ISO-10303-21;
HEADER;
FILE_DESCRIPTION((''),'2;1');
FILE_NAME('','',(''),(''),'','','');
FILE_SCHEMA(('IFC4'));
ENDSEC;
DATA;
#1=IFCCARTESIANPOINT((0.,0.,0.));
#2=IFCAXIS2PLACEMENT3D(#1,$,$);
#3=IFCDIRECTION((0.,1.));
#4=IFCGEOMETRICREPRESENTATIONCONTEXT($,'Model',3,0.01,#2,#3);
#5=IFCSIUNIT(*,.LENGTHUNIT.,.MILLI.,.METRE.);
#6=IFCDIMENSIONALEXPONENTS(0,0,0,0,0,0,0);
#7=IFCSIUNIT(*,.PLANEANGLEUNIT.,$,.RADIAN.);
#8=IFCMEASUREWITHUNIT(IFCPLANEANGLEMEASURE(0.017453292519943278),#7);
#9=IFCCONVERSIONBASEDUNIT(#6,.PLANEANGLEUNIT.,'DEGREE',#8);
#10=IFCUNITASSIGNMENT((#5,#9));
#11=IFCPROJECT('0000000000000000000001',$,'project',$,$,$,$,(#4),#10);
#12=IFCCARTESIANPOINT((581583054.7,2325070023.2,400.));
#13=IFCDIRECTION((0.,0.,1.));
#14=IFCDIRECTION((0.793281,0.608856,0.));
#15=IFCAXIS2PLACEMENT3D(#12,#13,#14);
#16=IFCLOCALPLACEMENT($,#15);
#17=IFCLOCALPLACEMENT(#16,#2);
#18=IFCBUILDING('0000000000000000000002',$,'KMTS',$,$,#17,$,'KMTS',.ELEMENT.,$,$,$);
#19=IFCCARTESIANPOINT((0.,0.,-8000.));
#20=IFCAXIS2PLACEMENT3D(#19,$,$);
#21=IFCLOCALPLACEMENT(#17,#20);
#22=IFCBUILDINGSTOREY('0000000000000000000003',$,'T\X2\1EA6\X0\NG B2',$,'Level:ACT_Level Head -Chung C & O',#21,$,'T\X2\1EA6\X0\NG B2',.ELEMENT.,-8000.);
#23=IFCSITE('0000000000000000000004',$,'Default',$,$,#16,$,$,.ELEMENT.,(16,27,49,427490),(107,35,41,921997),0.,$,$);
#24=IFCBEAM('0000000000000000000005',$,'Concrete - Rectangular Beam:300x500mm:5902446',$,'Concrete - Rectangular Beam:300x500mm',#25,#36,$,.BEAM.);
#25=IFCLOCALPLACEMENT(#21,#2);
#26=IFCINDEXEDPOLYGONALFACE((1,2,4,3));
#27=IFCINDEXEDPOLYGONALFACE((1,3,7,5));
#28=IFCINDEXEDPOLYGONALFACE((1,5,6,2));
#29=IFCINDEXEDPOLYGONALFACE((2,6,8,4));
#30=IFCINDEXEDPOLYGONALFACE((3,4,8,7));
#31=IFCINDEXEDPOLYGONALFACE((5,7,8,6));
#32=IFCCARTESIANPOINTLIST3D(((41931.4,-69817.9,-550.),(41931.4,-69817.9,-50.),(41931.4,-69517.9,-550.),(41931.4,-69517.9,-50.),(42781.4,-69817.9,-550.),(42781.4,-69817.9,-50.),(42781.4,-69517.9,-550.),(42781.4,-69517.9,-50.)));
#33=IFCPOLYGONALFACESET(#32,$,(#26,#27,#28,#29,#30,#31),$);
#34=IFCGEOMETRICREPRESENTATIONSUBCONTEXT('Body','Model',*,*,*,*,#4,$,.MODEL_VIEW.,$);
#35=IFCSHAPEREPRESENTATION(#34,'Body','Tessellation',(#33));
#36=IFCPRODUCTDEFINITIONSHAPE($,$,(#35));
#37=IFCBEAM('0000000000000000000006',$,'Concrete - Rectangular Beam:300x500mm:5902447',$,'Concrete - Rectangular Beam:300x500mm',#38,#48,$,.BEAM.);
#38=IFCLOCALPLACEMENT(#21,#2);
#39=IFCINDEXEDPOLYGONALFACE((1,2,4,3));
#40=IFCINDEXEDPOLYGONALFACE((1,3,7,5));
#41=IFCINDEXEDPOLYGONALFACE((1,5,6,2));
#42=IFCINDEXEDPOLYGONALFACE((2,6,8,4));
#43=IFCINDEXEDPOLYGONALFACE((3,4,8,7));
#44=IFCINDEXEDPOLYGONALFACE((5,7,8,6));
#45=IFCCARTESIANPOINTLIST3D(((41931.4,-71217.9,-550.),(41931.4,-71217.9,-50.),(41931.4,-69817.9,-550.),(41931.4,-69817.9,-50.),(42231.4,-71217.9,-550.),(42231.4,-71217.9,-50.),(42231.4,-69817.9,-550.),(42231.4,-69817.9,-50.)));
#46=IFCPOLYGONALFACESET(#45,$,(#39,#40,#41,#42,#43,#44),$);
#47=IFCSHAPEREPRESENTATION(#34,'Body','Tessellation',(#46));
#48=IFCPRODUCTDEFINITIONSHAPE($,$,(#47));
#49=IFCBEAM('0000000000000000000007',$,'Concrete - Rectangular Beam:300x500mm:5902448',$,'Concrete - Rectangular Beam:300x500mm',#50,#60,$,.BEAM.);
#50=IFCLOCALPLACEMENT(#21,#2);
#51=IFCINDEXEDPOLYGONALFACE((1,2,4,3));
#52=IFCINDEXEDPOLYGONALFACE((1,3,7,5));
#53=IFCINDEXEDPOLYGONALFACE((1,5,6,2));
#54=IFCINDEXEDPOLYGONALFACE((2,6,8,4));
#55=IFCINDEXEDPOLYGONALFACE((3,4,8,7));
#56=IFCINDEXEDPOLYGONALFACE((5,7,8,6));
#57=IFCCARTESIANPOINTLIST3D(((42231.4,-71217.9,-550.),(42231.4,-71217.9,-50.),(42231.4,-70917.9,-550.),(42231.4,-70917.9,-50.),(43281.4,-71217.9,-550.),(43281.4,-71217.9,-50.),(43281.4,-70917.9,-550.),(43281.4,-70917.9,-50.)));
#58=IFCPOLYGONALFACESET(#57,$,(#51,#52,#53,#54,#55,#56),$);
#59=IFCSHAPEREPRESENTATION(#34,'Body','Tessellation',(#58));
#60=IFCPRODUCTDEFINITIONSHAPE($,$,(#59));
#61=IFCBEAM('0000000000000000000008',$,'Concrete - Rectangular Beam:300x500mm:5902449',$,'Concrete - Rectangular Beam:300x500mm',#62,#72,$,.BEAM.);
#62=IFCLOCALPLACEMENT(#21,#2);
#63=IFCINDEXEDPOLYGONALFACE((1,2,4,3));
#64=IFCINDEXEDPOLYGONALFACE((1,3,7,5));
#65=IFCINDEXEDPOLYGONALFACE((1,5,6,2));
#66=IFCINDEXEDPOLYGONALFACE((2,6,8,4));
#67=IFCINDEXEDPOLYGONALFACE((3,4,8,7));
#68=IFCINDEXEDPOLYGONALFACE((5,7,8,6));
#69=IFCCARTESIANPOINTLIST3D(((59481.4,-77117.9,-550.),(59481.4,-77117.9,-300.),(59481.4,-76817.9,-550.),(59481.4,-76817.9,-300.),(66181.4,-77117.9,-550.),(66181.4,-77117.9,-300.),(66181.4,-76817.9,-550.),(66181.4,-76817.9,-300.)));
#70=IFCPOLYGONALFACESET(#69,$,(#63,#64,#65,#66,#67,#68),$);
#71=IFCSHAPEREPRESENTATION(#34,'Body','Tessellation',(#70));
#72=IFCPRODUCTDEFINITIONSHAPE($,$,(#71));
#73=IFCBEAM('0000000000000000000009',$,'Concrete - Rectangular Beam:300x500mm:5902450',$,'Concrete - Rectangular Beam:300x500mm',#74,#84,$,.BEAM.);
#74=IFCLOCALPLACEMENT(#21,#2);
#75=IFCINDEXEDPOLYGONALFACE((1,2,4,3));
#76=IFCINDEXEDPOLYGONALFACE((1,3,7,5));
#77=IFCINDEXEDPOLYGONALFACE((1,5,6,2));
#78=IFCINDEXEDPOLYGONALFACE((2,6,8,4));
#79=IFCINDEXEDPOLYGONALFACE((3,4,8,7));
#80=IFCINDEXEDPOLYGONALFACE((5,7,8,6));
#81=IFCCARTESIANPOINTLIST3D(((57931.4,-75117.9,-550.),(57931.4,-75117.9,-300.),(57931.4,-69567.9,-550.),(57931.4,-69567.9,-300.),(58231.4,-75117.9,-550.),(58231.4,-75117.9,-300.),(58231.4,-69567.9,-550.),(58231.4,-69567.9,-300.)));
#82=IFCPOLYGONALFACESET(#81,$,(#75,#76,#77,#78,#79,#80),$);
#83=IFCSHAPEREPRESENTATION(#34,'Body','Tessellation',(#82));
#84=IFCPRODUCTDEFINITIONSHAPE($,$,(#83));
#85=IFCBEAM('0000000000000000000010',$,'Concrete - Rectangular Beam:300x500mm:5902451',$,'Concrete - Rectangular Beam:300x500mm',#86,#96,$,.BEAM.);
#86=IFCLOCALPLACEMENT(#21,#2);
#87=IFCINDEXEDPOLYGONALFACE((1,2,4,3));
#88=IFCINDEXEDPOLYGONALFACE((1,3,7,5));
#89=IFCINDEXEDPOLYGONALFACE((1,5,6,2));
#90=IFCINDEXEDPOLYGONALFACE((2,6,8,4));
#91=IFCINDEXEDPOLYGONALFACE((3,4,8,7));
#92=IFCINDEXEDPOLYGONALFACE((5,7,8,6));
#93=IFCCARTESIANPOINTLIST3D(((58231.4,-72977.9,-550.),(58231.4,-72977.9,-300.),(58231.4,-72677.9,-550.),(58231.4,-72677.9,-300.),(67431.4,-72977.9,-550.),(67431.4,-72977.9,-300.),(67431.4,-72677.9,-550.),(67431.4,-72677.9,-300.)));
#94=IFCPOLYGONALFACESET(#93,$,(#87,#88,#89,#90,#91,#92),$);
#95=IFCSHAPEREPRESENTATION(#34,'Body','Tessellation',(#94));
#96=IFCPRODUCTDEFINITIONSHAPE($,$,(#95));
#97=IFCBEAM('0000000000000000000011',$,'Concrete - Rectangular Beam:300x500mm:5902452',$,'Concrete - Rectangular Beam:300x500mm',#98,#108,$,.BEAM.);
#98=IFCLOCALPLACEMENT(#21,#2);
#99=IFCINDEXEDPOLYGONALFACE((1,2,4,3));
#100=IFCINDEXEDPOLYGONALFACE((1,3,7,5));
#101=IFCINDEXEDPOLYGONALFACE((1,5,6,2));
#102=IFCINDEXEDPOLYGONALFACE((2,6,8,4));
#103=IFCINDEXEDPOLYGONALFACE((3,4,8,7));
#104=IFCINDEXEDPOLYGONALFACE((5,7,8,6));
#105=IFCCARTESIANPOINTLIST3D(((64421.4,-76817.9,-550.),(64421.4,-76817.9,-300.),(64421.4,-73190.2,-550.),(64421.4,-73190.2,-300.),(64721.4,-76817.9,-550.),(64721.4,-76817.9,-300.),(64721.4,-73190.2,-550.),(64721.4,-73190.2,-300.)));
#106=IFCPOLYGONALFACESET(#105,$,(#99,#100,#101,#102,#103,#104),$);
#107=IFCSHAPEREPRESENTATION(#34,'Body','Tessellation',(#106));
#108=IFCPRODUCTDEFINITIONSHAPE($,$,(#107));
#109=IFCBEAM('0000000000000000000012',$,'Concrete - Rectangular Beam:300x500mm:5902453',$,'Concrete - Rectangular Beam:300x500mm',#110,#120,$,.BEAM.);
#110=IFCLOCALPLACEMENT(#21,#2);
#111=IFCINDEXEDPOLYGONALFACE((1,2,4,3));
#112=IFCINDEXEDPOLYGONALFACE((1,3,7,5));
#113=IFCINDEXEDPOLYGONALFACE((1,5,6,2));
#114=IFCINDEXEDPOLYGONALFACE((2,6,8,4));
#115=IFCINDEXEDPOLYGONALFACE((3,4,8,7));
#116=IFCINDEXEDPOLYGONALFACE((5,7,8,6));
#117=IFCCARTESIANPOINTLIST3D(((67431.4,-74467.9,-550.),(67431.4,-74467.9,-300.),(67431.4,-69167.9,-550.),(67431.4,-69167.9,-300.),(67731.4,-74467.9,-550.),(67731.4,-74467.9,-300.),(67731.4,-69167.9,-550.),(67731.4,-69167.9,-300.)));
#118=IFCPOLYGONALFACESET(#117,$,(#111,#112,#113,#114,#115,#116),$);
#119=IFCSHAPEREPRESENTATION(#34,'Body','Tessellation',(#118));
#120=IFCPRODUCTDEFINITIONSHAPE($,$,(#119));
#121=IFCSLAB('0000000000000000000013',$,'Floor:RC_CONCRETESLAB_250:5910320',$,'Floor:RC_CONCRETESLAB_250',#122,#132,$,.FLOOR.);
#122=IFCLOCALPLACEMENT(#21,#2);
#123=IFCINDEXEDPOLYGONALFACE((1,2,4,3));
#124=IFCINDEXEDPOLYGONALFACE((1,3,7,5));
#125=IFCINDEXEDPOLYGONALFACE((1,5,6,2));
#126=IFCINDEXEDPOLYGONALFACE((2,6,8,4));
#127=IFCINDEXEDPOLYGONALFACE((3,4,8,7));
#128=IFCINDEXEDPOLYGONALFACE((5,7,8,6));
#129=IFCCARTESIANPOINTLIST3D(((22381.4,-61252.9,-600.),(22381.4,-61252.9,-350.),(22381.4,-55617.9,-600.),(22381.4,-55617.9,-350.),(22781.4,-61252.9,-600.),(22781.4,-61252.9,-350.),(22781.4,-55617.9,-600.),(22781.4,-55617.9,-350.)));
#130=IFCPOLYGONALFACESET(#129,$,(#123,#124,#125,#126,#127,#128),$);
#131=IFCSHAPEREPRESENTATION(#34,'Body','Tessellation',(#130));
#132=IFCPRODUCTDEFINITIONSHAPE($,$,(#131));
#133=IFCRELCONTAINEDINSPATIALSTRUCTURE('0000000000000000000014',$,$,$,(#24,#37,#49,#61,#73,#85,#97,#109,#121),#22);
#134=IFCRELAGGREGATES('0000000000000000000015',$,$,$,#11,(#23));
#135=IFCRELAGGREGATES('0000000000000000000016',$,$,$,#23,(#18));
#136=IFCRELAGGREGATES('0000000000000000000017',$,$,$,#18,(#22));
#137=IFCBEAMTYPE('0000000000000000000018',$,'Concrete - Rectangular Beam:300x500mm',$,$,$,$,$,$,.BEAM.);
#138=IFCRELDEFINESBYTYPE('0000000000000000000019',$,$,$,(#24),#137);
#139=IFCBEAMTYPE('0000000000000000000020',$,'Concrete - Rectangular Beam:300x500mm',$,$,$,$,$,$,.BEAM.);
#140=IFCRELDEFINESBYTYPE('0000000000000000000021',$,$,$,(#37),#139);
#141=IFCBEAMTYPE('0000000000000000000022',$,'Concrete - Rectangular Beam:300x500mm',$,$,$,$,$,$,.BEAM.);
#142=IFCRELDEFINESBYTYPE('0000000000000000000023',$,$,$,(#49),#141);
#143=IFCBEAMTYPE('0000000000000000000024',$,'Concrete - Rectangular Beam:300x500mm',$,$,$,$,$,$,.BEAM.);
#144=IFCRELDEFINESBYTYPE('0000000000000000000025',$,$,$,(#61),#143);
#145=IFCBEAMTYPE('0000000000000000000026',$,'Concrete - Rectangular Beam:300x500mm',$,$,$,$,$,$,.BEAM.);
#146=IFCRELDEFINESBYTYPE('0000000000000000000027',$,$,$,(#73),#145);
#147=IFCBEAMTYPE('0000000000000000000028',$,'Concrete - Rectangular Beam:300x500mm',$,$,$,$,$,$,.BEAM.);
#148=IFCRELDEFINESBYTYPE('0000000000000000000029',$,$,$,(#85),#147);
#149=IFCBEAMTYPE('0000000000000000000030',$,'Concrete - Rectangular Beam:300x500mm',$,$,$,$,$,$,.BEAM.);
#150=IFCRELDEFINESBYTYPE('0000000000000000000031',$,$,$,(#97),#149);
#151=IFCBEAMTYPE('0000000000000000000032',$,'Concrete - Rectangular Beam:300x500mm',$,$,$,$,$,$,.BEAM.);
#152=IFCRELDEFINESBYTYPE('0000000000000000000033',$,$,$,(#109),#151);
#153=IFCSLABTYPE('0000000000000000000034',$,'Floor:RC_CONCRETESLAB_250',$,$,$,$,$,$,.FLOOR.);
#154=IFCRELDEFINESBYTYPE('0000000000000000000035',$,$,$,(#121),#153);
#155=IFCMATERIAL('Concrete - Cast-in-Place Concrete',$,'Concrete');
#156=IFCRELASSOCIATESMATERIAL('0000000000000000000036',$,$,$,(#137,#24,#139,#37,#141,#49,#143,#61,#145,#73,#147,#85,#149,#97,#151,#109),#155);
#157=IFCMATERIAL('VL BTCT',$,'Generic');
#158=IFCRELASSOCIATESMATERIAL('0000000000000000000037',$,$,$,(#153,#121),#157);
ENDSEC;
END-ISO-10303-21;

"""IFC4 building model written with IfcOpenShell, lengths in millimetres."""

from ifc_helpers import new_model, entity, si_unit, converted_unit, direction, frame, origin, place, context, subcontext, project, spatial, indexed_curve, outline, extrude, source, transform, mapped, material, type_object, type_shapes, element, save


model = new_model("IFC4")

# Units and contexts
model_context = context("Model", 3, precision=0.01, world=origin(), true_north=direction((0.0, 1.0)))
body_context = subcontext(model_context, "Body", "Model", "MODEL_VIEW")
ifc_project = project(units=[si_unit("LENGTHUNIT", "METRE", prefix="MILLI"), converted_unit("PLANEANGLEUNIT", "DEGREE", entity("IfcPlaneAngleMeasure", 0.017453292519943278), si_unit("PLANEANGLEUNIT", "RADIAN"), dimensions=[0, 0, 0, 0, 0, 0, 0])], contexts=[model_context])

# Site, building, storey
site_placement = place(None, frame((581583054.7, 2325070023.2, 400.0), z_axis=(0.0, 0.0, 1.0), x_axis=(0.793281, 0.608856, 0.0)))
site = spatial("IfcSite", under=ifc_project, at=site_placement, Name="Default", CompositionType="ELEMENT", RefLatitude=(16, 27, 49, 427490), RefLongitude=(107, 35, 41, 921997), RefElevation=0.0)
building_placement = place(site_placement, origin())
building = spatial("IfcBuilding", under=site, at=building_placement, Name="KMTS", LongName="KMTS", CompositionType="ELEMENT")
storey_placement = place(building_placement, frame((0.0, 0.0, -8000.0)))
storey = spatial("IfcBuildingStorey", under=building, at=storey_placement, Name="TẦNG B2", ObjectType="Level:ACT_Level Head -Chung C & O", LongName="TẦNG B2", CompositionType="ELEMENT", Elevation=-8000.0)

# Shared definitions
ifc_material_1 = material(Name="VL BTCT", Category="Generic")

# Beams
ifc_material_2 = material(Name="Concrete - Cast-in-Place Concrete", Category="Concrete")
beam_type_1 = type_object("IfcBeamType", Name="Concrete - Rectangular Beam:300x500mm", PredefinedType="BEAM", material=ifc_material_2)
shared_shape_1 = source(origin(), body_context, "Body", "SweptSolid", [
    extrude(outline(indexed_curve([(-250.0, -150.0), (250.0, -150.0), (250.0, 150.0), (-250.0, 150.0), (-250.0, -150.0)], self_intersect=False)), frame((42781.4, -69667.9, -8300.0), z_axis=(-1.0, 0.0, 0.0), x_axis=(0.0, 0.0, -1.0)), (0.0, 0.0, 1.0), 850.0),
])
type_shapes(beam_type_1, [shared_shape_1])
beam_1_placement = place(storey_placement, frame((0.0, 0.0, 8000.0)))
element("IfcBeam", 1, at=beam_1_placement, inside=storey, type_object=beam_type_1, material=ifc_material_2, Name="Concrete - Rectangular Beam:300x500mm:5902446", ObjectType="Concrete - Rectangular Beam:300x500mm", PredefinedType="BEAM", context=body_context, shape_type="MappedRepresentation", body=[
    mapped(shared_shape_1, transform((0.0, 0.0, 0.0), scale=1.0)),
])
beam_type_2 = type_object("IfcBeamType", Name="Concrete - Rectangular Beam:300x500mm", PredefinedType="BEAM", material=ifc_material_2)
shared_shape_2 = source(origin(), body_context, "Body", "SweptSolid", [
    extrude(outline(indexed_curve([(-150.0, -250.0), (150.0, -250.0), (150.0, 250.0), (-150.0, 250.0), (-150.0, -250.0)], self_intersect=False)), frame((42081.4, -69817.9, -8300.0), z_axis=(0.0, -1.0, 0.0), x_axis=(-1.0, 0.0, 0.0)), (0.0, 0.0, 1.0), 1400.0),
])
type_shapes(beam_type_2, [shared_shape_2])
beam_2_placement = place(storey_placement, frame((0.0, 0.0, 8000.0)))
element("IfcBeam", 2, at=beam_2_placement, inside=storey, type_object=beam_type_2, material=ifc_material_2, Name="Concrete - Rectangular Beam:300x500mm:5902447", ObjectType="Concrete - Rectangular Beam:300x500mm", PredefinedType="BEAM", context=body_context, shape_type="MappedRepresentation", body=[
    mapped(shared_shape_2, transform((0.0, 0.0, 0.0), scale=1.0)),
])
beam_type_3 = type_object("IfcBeamType", Name="Concrete - Rectangular Beam:300x500mm", PredefinedType="BEAM", material=ifc_material_2)
shared_shape_3 = source(origin(), body_context, "Body", "SweptSolid", [
    extrude(outline(indexed_curve([(-250.0, -150.0), (250.0, -150.0), (250.0, 150.0), (-250.0, 150.0), (-250.0, -150.0)], self_intersect=False)), frame((42231.4, -71067.9, -8300.0), z_axis=(1.0, 0.0, 0.0), x_axis=(0.0, 0.0, -1.0)), (0.0, 0.0, 1.0), 1050.0),
])
type_shapes(beam_type_3, [shared_shape_3])
beam_3_placement = place(storey_placement, frame((0.0, 0.0, 8000.0)))
element("IfcBeam", 3, at=beam_3_placement, inside=storey, type_object=beam_type_3, material=ifc_material_2, Name="Concrete - Rectangular Beam:300x500mm:5902448", ObjectType="Concrete - Rectangular Beam:300x500mm", PredefinedType="BEAM", context=body_context, shape_type="MappedRepresentation", body=[
    mapped(shared_shape_3, transform((0.0, 0.0, 0.0), scale=1.0)),
])
beam_type_4 = type_object("IfcBeamType", Name="Concrete - Rectangular Beam:300x500mm", PredefinedType="BEAM", material=ifc_material_2)
shared_shape_4 = source(origin(), body_context, "Body", "SweptSolid", [
    extrude(outline(indexed_curve([(-125.0, -150.0), (125.0, -150.0), (125.0, 150.0), (-125.0, 150.0), (-125.0, -150.0)], self_intersect=False)), frame((66181.4, -76967.9, -8425.0), z_axis=(-1.0, 0.0, 0.0), x_axis=(0.0, 0.0, -1.0)), (0.0, 0.0, 1.0), 6700.0),
])
type_shapes(beam_type_4, [shared_shape_4])
beam_4_placement = place(storey_placement, frame((0.0, 0.0, 8000.0)))
element("IfcBeam", 4, at=beam_4_placement, inside=storey, type_object=beam_type_4, material=ifc_material_2, Name="Concrete - Rectangular Beam:300x500mm:5902449", ObjectType="Concrete - Rectangular Beam:300x500mm", PredefinedType="BEAM", context=body_context, shape_type="MappedRepresentation", body=[
    mapped(shared_shape_4, transform((0.0, 0.0, 0.0), scale=1.0)),
])
beam_type_5 = type_object("IfcBeamType", Name="Concrete - Rectangular Beam:300x500mm", PredefinedType="BEAM", material=ifc_material_2)
shared_shape_5 = source(origin(), body_context, "Body", "SweptSolid", [
    extrude(outline(indexed_curve([(-150.0, -125.0), (150.0, -125.0), (150.0, 125.0), (-150.0, 125.0), (-150.0, -125.0)], self_intersect=False)), frame((58081.4, -75117.9, -8425.0), z_axis=(0.0, 1.0, 0.0), x_axis=(-1.0, 0.0, 0.0)), (0.0, 0.0, 1.0), 5550.0),
])
type_shapes(beam_type_5, [shared_shape_5])
beam_5_placement = place(storey_placement, frame((0.0, 0.0, 8000.0)))
element("IfcBeam", 5, at=beam_5_placement, inside=storey, type_object=beam_type_5, material=ifc_material_2, Name="Concrete - Rectangular Beam:300x500mm:5902450", ObjectType="Concrete - Rectangular Beam:300x500mm", PredefinedType="BEAM", context=body_context, shape_type="MappedRepresentation", body=[
    mapped(shared_shape_5, transform((0.0, 0.0, 0.0), scale=1.0)),
])
beam_type_6 = type_object("IfcBeamType", Name="Concrete - Rectangular Beam:300x500mm", PredefinedType="BEAM", material=ifc_material_2)
shared_shape_6 = source(origin(), body_context, "Body", "SweptSolid", [
    extrude(outline(indexed_curve([(-125.0, -150.0), (125.0, -150.0), (125.0, 150.0), (-125.0, 150.0), (-125.0, -150.0)], self_intersect=False)), frame((58231.4, -72827.9, -8425.0), z_axis=(1.0, 0.0, 0.0), x_axis=(0.0, 0.0, -1.0)), (0.0, 0.0, 1.0), 9200.0),
])
type_shapes(beam_type_6, [shared_shape_6])
beam_6_placement = place(storey_placement, frame((0.0, 0.0, 8000.0)))
element("IfcBeam", 6, at=beam_6_placement, inside=storey, type_object=beam_type_6, material=ifc_material_2, Name="Concrete - Rectangular Beam:300x500mm:5902451", ObjectType="Concrete - Rectangular Beam:300x500mm", PredefinedType="BEAM", context=body_context, shape_type="MappedRepresentation", body=[
    mapped(shared_shape_6, transform((0.0, 0.0, 0.0), scale=1.0)),
])
beam_type_7 = type_object("IfcBeamType", Name="Concrete - Rectangular Beam:300x500mm", PredefinedType="BEAM", material=ifc_material_2)
shared_shape_7 = source(origin(), body_context, "Body", "SweptSolid", [
    extrude(outline(indexed_curve([(-150.0, -125.0), (150.0, -125.0), (150.0, 125.0), (-150.0, 125.0), (-150.0, -125.0)], self_intersect=False)), frame((64571.4, -73190.2, -8425.0), z_axis=(0.0, -1.0, 0.0), x_axis=(-1.0, 0.0, 0.0)), (0.0, 0.0, 1.0), 3627.7),
])
type_shapes(beam_type_7, [shared_shape_7])
beam_7_placement = place(storey_placement, frame((0.0, 0.0, 8000.0)))
element("IfcBeam", 7, at=beam_7_placement, inside=storey, type_object=beam_type_7, material=ifc_material_2, Name="Concrete - Rectangular Beam:300x500mm:5902452", ObjectType="Concrete - Rectangular Beam:300x500mm", PredefinedType="BEAM", context=body_context, shape_type="MappedRepresentation", body=[
    mapped(shared_shape_7, transform((0.0, 0.0, 0.0), scale=1.0)),
])
beam_type_8 = type_object("IfcBeamType", Name="Concrete - Rectangular Beam:300x500mm", PredefinedType="BEAM", material=ifc_material_2)
shared_shape_8 = source(origin(), body_context, "Body", "SweptSolid", [
    extrude(outline(indexed_curve([(-150.0, -125.0), (150.0, -125.0), (150.0, 125.0), (-150.0, 125.0), (-150.0, -125.0)], self_intersect=False)), frame((67581.4, -69167.9, -8425.0), z_axis=(0.0, -1.0, 0.0), x_axis=(-1.0, 0.0, 0.0)), (0.0, 0.0, 1.0), 5300.0),
])
type_shapes(beam_type_8, [shared_shape_8])
beam_8_placement = place(storey_placement, frame((0.0, 0.0, 8000.0)))
element("IfcBeam", 8, at=beam_8_placement, inside=storey, type_object=beam_type_8, material=ifc_material_2, Name="Concrete - Rectangular Beam:300x500mm:5902453", ObjectType="Concrete - Rectangular Beam:300x500mm", PredefinedType="BEAM", context=body_context, shape_type="MappedRepresentation", body=[
    mapped(shared_shape_8, transform((0.0, 0.0, 0.0), scale=1.0)),
])

# Slab
slab_type_1 = type_object("IfcSlabType", Name="Floor:RC_CONCRETESLAB_250", PredefinedType="FLOOR", material=ifc_material_1)
slab_1_placement = place(storey_placement, origin())
element("IfcSlab", 9, at=slab_1_placement, inside=storey, type_object=slab_type_1, material=ifc_material_1, Name="Floor:RC_CONCRETESLAB_250:5910320", ObjectType="Floor:RC_CONCRETESLAB_250", PredefinedType="FLOOR", context=body_context, shape_type="SweptSolid", body=[
    extrude(outline(indexed_curve([(-2817.5, -200.0), (2817.5, -200.0), (2817.5, 200.0), (-2817.5, 200.0), (-2817.5, -200.0)], self_intersect=False)), frame((22581.4, -58435.4, -350.0), z_axis=(0.0, 0.0, -1.0), x_axis=(0.0, 1.0, 0.0)), (0.0, 0.0, 1.0), 250.0),
])

save(model, "model.ifc")
